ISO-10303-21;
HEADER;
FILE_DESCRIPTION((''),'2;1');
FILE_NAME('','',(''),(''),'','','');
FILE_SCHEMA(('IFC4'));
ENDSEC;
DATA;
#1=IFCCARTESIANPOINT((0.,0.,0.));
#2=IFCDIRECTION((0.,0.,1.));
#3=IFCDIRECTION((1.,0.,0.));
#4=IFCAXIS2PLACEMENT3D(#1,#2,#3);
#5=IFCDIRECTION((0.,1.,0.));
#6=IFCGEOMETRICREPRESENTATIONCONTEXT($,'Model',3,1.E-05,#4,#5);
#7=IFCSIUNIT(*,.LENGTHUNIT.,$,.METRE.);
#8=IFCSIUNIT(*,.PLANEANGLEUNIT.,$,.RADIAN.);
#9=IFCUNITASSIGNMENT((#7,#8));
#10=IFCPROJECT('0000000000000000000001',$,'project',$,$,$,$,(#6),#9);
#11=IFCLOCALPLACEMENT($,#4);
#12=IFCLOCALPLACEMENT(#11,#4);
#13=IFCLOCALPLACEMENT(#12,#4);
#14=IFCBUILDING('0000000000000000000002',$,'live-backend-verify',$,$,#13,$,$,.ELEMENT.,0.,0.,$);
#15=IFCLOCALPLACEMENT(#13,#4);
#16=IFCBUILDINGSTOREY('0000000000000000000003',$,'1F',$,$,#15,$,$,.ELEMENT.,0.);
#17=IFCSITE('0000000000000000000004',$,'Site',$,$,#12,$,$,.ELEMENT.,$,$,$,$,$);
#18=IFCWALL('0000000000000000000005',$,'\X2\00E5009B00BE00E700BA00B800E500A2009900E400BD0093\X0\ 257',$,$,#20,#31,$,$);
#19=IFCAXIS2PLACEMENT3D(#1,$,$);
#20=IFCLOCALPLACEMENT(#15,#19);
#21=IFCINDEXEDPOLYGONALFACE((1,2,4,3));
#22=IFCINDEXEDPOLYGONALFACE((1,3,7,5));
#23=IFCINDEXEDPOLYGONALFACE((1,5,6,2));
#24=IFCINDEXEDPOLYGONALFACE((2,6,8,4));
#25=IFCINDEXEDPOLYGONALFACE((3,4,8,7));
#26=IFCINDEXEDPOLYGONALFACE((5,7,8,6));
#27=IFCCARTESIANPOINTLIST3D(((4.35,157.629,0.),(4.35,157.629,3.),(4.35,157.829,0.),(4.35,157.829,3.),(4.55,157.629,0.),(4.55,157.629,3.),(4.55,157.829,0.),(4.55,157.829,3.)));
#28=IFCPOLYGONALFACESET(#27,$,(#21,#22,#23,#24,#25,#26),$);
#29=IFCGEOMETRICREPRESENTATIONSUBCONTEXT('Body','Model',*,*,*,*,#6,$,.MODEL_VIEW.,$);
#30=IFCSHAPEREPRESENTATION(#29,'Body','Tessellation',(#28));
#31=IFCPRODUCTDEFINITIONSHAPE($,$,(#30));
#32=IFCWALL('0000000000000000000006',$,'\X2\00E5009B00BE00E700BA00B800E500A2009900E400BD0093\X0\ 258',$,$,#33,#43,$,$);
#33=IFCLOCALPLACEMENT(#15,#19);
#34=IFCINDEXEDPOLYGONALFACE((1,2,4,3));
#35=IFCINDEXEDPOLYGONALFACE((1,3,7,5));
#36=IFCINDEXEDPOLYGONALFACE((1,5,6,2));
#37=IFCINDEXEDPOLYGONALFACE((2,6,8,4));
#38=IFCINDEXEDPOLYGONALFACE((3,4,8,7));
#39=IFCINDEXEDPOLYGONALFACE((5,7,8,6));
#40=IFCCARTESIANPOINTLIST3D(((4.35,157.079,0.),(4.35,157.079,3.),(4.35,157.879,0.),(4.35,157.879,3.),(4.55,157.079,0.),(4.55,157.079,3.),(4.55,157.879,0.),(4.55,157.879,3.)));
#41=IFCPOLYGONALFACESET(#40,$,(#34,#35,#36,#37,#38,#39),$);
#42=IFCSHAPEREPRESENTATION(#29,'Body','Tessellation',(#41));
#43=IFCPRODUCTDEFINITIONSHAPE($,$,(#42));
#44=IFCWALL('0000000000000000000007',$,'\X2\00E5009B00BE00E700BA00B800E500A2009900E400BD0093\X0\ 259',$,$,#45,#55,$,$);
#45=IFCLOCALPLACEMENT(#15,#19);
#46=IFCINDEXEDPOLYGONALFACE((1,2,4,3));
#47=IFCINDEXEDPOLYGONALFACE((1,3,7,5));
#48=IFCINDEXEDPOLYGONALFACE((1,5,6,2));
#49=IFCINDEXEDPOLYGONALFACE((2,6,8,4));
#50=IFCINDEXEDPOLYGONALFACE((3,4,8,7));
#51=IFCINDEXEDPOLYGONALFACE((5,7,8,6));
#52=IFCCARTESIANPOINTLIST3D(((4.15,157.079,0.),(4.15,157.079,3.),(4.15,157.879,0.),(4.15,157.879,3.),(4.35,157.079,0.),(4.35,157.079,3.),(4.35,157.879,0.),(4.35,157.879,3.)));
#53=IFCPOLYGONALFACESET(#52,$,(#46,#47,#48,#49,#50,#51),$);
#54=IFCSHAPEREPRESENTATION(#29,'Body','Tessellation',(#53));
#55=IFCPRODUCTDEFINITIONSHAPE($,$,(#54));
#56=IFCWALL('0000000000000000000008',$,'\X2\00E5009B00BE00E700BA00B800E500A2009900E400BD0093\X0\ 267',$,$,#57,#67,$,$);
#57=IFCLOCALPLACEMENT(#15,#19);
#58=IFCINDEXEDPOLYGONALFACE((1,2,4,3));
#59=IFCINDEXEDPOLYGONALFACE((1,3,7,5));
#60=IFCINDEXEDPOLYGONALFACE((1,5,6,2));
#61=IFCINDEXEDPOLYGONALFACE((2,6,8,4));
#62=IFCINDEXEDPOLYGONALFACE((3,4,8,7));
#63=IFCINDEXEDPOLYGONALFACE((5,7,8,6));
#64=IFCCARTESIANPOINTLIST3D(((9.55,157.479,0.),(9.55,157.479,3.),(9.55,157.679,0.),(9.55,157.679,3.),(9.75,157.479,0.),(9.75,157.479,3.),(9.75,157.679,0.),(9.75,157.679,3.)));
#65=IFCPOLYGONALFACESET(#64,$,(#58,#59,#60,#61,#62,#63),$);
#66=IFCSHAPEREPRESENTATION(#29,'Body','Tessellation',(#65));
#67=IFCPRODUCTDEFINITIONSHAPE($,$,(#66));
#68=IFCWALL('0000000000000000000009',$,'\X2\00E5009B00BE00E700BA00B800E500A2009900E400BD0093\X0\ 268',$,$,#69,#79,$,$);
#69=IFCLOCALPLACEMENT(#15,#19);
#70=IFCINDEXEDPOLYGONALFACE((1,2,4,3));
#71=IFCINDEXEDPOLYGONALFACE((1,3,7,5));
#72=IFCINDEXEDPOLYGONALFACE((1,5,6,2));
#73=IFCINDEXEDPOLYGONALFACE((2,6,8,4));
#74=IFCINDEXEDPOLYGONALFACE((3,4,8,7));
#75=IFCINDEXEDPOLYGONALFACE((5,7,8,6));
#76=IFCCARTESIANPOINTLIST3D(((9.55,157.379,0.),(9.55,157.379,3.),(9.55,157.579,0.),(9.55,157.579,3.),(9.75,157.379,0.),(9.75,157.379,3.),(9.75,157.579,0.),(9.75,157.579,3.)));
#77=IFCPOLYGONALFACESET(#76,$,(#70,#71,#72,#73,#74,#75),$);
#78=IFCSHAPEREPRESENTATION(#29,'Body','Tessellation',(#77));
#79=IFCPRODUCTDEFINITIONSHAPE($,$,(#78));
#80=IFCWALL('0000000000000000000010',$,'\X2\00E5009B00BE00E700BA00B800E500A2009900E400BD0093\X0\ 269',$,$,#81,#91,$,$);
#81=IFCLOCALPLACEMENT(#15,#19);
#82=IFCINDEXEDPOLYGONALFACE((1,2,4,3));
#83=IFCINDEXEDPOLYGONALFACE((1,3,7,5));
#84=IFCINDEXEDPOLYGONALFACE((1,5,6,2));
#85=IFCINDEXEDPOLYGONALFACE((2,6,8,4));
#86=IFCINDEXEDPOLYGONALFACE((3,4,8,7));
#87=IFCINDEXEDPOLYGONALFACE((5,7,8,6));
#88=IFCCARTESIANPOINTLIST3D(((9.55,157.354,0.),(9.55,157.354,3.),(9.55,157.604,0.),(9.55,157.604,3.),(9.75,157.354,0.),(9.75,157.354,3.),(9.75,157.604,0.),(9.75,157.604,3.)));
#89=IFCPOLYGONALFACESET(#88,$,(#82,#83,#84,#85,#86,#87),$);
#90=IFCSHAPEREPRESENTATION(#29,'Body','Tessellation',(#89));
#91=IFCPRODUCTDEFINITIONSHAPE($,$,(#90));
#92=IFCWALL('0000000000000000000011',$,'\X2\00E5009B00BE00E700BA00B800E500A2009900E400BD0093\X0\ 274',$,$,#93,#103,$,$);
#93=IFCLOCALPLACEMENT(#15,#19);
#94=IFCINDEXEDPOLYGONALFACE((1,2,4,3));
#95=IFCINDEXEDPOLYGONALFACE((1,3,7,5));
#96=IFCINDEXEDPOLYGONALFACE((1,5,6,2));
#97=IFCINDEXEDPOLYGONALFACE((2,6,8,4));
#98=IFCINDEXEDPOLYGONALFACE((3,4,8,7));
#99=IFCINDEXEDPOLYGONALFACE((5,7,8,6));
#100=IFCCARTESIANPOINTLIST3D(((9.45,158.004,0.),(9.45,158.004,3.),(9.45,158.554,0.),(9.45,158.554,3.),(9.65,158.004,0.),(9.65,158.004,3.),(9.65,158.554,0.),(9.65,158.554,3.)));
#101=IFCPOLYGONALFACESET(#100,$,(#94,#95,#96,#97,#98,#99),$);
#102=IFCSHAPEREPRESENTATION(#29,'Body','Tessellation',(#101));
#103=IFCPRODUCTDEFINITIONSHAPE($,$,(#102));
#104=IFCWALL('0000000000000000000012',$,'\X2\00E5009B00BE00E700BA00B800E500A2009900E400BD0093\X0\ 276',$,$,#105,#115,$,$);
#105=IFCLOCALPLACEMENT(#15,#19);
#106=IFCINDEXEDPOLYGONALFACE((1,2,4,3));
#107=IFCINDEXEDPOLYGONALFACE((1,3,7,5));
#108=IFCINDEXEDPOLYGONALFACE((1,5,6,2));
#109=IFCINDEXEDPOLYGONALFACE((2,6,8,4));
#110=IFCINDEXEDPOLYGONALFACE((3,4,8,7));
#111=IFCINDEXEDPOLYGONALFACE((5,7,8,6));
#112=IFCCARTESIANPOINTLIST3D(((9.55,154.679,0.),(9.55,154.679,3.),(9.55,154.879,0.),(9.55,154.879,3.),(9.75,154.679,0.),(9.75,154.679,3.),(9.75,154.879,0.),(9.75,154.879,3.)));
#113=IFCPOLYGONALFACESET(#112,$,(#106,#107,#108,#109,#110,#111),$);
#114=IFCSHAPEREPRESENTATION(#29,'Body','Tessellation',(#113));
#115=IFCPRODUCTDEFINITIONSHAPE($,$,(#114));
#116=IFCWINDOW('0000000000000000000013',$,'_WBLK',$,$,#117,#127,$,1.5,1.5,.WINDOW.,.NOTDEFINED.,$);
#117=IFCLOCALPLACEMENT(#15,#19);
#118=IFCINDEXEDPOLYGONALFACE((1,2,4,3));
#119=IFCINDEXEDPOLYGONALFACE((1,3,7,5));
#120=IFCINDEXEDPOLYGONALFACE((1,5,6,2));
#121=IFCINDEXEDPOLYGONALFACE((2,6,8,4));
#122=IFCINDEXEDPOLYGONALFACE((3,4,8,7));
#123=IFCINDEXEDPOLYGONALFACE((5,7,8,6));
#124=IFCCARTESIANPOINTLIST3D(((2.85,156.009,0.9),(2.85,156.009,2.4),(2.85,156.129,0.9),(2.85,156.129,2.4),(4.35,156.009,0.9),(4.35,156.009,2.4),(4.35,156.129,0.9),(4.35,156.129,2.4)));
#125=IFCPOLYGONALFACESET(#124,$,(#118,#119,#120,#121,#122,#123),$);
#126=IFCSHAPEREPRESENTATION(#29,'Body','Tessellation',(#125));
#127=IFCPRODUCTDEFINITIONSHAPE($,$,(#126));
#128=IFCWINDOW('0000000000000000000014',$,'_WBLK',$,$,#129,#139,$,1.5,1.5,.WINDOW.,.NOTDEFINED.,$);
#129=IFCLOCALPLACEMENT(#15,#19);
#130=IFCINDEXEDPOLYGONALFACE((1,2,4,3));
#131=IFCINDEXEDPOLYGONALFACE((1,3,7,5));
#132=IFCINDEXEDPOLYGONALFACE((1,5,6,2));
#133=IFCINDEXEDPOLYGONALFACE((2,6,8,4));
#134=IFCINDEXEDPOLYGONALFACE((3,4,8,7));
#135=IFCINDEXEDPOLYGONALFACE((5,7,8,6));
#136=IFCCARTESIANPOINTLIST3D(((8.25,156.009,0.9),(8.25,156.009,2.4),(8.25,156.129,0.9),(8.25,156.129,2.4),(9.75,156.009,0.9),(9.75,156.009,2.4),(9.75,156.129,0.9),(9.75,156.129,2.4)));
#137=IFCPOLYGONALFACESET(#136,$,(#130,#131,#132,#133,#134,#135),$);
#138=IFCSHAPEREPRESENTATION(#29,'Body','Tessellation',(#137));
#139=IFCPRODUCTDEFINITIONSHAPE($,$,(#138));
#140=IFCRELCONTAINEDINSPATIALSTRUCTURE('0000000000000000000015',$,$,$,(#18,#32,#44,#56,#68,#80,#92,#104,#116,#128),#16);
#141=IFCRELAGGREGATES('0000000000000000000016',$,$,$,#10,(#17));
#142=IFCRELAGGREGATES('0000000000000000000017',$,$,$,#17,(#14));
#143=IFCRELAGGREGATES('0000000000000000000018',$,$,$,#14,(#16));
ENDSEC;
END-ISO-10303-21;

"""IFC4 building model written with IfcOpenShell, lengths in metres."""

from ifc_helpers import new_model, si_unit, direction, frame, frame_2d, origin_with_axes, place, context, subcontext, project, spatial, rectangle, extrude, element, save


model = new_model("IFC4")

# Units and contexts
model_context = context("Model", 3, precision=1e-05, world=origin_with_axes(), true_north=direction((0.0, 1.0, 0.0)))
body_context = subcontext(model_context, "Body", "Model", "MODEL_VIEW")
ifc_project = project(units=[si_unit("LENGTHUNIT", "METRE"), si_unit("PLANEANGLEUNIT", "RADIAN")], contexts=[model_context])

# Site, building, storey
placement = place(None, origin_with_axes())
site_placement = place(placement, origin_with_axes())
site = spatial("IfcSite", under=ifc_project, at=site_placement, Name="Site", CompositionType="ELEMENT")
building_placement = place(site_placement, origin_with_axes())
building = spatial("IfcBuilding", under=site, at=building_placement, Name="live-backend-verify", CompositionType="ELEMENT", ElevationOfRefHeight=0.0, ElevationOfTerrain=0.0)
storey_placement = place(building_placement, origin_with_axes())
storey = spatial("IfcBuildingStorey", under=building, at=storey_placement, Name="1F", CompositionType="ELEMENT", Elevation=0.0)

# Walls
for number, where, z_axis, x_axis, name in (
    (1, (4.45, 157.729, 0.0), (0.0, 0.0, 1.0), (-1.0, 0.0, 0.0), "å\u009b¾çº¸å¢\u0099ä½\u0093 257"),
):
    element("IfcWall", number, at=place(storey_placement, frame(where, z_axis=z_axis, x_axis=x_axis)), inside=storey, Name=name, context=body_context, shape_type="SweptSolid", body=[
        extrude(rectangle(XDim=0.2, YDim=0.2, at=frame_2d((0.0, 0.0), x_axis=(1.0, 0.0, 0.0))), frame((0.0, 0.0, 0.0), z_axis=(0.0, 0.0, 1.0)), (0.0, 0.0, 1.0), 3.0),
    ])
for number, where, z_axis, x_axis, name in (
    (2, (4.45, 157.479, 0.0), (0.0, 0.0, 1.0), (0.0, 1.0, 0.0), "å\u009b¾çº¸å¢\u0099ä½\u0093 258"),
    (3, (4.25, 157.479, 0.0), (0.0, 0.0, 1.0), (0.0, 1.0, 0.0), "å\u009b¾çº¸å¢\u0099ä½\u0093 259"),
):
    element("IfcWall", number, at=place(storey_placement, frame(where, z_axis=z_axis, x_axis=x_axis)), inside=storey, Name=name, context=body_context, shape_type="SweptSolid", body=[
        extrude(rectangle(XDim=0.8, YDim=0.2, at=frame_2d((0.0, 0.0), x_axis=(1.0, 0.0, 0.0))), frame((0.0, 0.0, 0.0), z_axis=(0.0, 0.0, 1.0)), (0.0, 0.0, 1.0), 3.0),
    ])
for number, where, z_axis, x_axis, name in (
    (4, (9.65, 157.579, 0.0), (0.0, 0.0, 1.0), (1.0, 0.0, 0.0), "å\u009b¾çº¸å¢\u0099ä½\u0093 267"),
    (5, (9.65, 157.479, 0.0), (0.0, 0.0, 1.0), (1.0, 0.0, 0.0), "å\u009b¾çº¸å¢\u0099ä½\u0093 268"),
):
    element("IfcWall", number, at=place(storey_placement, frame(where, z_axis=z_axis, x_axis=x_axis)), inside=storey, Name=name, context=body_context, shape_type="SweptSolid", body=[
        extrude(rectangle(XDim=0.2, YDim=0.2, at=frame_2d((0.0, 0.0), x_axis=(1.0, 0.0, 0.0))), frame((0.0, 0.0, 0.0), z_axis=(0.0, 0.0, 1.0)), (0.0, 0.0, 1.0), 3.0),
    ])
wall_1_placement = place(storey_placement, frame((9.65, 157.479, 0.0), z_axis=(0.0, 0.0, 1.0), x_axis=(0.0, 1.0, 0.0)))
element("IfcWall", 6, at=wall_1_placement, inside=storey, Name="å\u009b¾çº¸å¢\u0099ä½\u0093 269", context=body_context, shape_type="SweptSolid", body=[
    extrude(rectangle(XDim=0.25, YDim=0.2, at=frame_2d((0.0, 0.0), x_axis=(1.0, 0.0, 0.0))), frame((0.0, 0.0, 0.0), z_axis=(0.0, 0.0, 1.0)), (0.0, 0.0, 1.0), 3.0),
])
wall_2_placement = place(storey_placement, frame((9.55, 158.279, 0.0), z_axis=(0.0, 0.0, 1.0), x_axis=(0.0, -1.0, 0.0)))
element("IfcWall", 7, at=wall_2_placement, inside=storey, Name="å\u009b¾çº¸å¢\u0099ä½\u0093 274", context=body_context, shape_type="SweptSolid", body=[
    extrude(rectangle(XDim=0.55, YDim=0.2, at=frame_2d((0.0, 0.0), x_axis=(1.0, 0.0, 0.0))), frame((0.0, 0.0, 0.0), z_axis=(0.0, 0.0, 1.0)), (0.0, 0.0, 1.0), 3.0),
])
wall_3_placement = place(storey_placement, frame((9.65, 154.779, 0.0), z_axis=(0.0, 0.0, 1.0), x_axis=(1.0, 0.0, 0.0)))
element("IfcWall", 8, at=wall_3_placement, inside=storey, Name="å\u009b¾çº¸å¢\u0099ä½\u0093 276", context=body_context, shape_type="SweptSolid", body=[
    extrude(rectangle(XDim=0.2, YDim=0.2, at=frame_2d((0.0, 0.0), x_axis=(1.0, 0.0, 0.0))), frame((0.0, 0.0, 0.0), z_axis=(0.0, 0.0, 1.0)), (0.0, 0.0, 1.0), 3.0),
])

# Windows
for number, where, z_axis, x_axis, name in (
    (9, (3.6, 156.069, 0.9), (0.0, 0.0, 1.0), (1.0, 0.0, 0.0), "_WBLK"),
    (10, (9.0, 156.069, 0.9), (0.0, 0.0, 1.0), (1.0, 0.0, 0.0), "_WBLK"),
):
    element("IfcWindow", number, at=place(storey_placement, frame(where, z_axis=z_axis, x_axis=x_axis)), inside=storey, Name=name, OverallHeight=1.5, OverallWidth=1.5, PartitioningType="NOTDEFINED", PredefinedType="WINDOW", context=body_context, shape_type="SweptSolid", body=[
        extrude(rectangle(XDim=1.5, YDim=0.12, at=frame_2d((0.0, 0.0), x_axis=(1.0, 0.0, 0.0))), frame((0.0, 0.0, 0.0), z_axis=(0.0, 0.0, 1.0)), (0.0, 0.0, 1.0), 1.5),
    ])

save(model, "model.ifc")
